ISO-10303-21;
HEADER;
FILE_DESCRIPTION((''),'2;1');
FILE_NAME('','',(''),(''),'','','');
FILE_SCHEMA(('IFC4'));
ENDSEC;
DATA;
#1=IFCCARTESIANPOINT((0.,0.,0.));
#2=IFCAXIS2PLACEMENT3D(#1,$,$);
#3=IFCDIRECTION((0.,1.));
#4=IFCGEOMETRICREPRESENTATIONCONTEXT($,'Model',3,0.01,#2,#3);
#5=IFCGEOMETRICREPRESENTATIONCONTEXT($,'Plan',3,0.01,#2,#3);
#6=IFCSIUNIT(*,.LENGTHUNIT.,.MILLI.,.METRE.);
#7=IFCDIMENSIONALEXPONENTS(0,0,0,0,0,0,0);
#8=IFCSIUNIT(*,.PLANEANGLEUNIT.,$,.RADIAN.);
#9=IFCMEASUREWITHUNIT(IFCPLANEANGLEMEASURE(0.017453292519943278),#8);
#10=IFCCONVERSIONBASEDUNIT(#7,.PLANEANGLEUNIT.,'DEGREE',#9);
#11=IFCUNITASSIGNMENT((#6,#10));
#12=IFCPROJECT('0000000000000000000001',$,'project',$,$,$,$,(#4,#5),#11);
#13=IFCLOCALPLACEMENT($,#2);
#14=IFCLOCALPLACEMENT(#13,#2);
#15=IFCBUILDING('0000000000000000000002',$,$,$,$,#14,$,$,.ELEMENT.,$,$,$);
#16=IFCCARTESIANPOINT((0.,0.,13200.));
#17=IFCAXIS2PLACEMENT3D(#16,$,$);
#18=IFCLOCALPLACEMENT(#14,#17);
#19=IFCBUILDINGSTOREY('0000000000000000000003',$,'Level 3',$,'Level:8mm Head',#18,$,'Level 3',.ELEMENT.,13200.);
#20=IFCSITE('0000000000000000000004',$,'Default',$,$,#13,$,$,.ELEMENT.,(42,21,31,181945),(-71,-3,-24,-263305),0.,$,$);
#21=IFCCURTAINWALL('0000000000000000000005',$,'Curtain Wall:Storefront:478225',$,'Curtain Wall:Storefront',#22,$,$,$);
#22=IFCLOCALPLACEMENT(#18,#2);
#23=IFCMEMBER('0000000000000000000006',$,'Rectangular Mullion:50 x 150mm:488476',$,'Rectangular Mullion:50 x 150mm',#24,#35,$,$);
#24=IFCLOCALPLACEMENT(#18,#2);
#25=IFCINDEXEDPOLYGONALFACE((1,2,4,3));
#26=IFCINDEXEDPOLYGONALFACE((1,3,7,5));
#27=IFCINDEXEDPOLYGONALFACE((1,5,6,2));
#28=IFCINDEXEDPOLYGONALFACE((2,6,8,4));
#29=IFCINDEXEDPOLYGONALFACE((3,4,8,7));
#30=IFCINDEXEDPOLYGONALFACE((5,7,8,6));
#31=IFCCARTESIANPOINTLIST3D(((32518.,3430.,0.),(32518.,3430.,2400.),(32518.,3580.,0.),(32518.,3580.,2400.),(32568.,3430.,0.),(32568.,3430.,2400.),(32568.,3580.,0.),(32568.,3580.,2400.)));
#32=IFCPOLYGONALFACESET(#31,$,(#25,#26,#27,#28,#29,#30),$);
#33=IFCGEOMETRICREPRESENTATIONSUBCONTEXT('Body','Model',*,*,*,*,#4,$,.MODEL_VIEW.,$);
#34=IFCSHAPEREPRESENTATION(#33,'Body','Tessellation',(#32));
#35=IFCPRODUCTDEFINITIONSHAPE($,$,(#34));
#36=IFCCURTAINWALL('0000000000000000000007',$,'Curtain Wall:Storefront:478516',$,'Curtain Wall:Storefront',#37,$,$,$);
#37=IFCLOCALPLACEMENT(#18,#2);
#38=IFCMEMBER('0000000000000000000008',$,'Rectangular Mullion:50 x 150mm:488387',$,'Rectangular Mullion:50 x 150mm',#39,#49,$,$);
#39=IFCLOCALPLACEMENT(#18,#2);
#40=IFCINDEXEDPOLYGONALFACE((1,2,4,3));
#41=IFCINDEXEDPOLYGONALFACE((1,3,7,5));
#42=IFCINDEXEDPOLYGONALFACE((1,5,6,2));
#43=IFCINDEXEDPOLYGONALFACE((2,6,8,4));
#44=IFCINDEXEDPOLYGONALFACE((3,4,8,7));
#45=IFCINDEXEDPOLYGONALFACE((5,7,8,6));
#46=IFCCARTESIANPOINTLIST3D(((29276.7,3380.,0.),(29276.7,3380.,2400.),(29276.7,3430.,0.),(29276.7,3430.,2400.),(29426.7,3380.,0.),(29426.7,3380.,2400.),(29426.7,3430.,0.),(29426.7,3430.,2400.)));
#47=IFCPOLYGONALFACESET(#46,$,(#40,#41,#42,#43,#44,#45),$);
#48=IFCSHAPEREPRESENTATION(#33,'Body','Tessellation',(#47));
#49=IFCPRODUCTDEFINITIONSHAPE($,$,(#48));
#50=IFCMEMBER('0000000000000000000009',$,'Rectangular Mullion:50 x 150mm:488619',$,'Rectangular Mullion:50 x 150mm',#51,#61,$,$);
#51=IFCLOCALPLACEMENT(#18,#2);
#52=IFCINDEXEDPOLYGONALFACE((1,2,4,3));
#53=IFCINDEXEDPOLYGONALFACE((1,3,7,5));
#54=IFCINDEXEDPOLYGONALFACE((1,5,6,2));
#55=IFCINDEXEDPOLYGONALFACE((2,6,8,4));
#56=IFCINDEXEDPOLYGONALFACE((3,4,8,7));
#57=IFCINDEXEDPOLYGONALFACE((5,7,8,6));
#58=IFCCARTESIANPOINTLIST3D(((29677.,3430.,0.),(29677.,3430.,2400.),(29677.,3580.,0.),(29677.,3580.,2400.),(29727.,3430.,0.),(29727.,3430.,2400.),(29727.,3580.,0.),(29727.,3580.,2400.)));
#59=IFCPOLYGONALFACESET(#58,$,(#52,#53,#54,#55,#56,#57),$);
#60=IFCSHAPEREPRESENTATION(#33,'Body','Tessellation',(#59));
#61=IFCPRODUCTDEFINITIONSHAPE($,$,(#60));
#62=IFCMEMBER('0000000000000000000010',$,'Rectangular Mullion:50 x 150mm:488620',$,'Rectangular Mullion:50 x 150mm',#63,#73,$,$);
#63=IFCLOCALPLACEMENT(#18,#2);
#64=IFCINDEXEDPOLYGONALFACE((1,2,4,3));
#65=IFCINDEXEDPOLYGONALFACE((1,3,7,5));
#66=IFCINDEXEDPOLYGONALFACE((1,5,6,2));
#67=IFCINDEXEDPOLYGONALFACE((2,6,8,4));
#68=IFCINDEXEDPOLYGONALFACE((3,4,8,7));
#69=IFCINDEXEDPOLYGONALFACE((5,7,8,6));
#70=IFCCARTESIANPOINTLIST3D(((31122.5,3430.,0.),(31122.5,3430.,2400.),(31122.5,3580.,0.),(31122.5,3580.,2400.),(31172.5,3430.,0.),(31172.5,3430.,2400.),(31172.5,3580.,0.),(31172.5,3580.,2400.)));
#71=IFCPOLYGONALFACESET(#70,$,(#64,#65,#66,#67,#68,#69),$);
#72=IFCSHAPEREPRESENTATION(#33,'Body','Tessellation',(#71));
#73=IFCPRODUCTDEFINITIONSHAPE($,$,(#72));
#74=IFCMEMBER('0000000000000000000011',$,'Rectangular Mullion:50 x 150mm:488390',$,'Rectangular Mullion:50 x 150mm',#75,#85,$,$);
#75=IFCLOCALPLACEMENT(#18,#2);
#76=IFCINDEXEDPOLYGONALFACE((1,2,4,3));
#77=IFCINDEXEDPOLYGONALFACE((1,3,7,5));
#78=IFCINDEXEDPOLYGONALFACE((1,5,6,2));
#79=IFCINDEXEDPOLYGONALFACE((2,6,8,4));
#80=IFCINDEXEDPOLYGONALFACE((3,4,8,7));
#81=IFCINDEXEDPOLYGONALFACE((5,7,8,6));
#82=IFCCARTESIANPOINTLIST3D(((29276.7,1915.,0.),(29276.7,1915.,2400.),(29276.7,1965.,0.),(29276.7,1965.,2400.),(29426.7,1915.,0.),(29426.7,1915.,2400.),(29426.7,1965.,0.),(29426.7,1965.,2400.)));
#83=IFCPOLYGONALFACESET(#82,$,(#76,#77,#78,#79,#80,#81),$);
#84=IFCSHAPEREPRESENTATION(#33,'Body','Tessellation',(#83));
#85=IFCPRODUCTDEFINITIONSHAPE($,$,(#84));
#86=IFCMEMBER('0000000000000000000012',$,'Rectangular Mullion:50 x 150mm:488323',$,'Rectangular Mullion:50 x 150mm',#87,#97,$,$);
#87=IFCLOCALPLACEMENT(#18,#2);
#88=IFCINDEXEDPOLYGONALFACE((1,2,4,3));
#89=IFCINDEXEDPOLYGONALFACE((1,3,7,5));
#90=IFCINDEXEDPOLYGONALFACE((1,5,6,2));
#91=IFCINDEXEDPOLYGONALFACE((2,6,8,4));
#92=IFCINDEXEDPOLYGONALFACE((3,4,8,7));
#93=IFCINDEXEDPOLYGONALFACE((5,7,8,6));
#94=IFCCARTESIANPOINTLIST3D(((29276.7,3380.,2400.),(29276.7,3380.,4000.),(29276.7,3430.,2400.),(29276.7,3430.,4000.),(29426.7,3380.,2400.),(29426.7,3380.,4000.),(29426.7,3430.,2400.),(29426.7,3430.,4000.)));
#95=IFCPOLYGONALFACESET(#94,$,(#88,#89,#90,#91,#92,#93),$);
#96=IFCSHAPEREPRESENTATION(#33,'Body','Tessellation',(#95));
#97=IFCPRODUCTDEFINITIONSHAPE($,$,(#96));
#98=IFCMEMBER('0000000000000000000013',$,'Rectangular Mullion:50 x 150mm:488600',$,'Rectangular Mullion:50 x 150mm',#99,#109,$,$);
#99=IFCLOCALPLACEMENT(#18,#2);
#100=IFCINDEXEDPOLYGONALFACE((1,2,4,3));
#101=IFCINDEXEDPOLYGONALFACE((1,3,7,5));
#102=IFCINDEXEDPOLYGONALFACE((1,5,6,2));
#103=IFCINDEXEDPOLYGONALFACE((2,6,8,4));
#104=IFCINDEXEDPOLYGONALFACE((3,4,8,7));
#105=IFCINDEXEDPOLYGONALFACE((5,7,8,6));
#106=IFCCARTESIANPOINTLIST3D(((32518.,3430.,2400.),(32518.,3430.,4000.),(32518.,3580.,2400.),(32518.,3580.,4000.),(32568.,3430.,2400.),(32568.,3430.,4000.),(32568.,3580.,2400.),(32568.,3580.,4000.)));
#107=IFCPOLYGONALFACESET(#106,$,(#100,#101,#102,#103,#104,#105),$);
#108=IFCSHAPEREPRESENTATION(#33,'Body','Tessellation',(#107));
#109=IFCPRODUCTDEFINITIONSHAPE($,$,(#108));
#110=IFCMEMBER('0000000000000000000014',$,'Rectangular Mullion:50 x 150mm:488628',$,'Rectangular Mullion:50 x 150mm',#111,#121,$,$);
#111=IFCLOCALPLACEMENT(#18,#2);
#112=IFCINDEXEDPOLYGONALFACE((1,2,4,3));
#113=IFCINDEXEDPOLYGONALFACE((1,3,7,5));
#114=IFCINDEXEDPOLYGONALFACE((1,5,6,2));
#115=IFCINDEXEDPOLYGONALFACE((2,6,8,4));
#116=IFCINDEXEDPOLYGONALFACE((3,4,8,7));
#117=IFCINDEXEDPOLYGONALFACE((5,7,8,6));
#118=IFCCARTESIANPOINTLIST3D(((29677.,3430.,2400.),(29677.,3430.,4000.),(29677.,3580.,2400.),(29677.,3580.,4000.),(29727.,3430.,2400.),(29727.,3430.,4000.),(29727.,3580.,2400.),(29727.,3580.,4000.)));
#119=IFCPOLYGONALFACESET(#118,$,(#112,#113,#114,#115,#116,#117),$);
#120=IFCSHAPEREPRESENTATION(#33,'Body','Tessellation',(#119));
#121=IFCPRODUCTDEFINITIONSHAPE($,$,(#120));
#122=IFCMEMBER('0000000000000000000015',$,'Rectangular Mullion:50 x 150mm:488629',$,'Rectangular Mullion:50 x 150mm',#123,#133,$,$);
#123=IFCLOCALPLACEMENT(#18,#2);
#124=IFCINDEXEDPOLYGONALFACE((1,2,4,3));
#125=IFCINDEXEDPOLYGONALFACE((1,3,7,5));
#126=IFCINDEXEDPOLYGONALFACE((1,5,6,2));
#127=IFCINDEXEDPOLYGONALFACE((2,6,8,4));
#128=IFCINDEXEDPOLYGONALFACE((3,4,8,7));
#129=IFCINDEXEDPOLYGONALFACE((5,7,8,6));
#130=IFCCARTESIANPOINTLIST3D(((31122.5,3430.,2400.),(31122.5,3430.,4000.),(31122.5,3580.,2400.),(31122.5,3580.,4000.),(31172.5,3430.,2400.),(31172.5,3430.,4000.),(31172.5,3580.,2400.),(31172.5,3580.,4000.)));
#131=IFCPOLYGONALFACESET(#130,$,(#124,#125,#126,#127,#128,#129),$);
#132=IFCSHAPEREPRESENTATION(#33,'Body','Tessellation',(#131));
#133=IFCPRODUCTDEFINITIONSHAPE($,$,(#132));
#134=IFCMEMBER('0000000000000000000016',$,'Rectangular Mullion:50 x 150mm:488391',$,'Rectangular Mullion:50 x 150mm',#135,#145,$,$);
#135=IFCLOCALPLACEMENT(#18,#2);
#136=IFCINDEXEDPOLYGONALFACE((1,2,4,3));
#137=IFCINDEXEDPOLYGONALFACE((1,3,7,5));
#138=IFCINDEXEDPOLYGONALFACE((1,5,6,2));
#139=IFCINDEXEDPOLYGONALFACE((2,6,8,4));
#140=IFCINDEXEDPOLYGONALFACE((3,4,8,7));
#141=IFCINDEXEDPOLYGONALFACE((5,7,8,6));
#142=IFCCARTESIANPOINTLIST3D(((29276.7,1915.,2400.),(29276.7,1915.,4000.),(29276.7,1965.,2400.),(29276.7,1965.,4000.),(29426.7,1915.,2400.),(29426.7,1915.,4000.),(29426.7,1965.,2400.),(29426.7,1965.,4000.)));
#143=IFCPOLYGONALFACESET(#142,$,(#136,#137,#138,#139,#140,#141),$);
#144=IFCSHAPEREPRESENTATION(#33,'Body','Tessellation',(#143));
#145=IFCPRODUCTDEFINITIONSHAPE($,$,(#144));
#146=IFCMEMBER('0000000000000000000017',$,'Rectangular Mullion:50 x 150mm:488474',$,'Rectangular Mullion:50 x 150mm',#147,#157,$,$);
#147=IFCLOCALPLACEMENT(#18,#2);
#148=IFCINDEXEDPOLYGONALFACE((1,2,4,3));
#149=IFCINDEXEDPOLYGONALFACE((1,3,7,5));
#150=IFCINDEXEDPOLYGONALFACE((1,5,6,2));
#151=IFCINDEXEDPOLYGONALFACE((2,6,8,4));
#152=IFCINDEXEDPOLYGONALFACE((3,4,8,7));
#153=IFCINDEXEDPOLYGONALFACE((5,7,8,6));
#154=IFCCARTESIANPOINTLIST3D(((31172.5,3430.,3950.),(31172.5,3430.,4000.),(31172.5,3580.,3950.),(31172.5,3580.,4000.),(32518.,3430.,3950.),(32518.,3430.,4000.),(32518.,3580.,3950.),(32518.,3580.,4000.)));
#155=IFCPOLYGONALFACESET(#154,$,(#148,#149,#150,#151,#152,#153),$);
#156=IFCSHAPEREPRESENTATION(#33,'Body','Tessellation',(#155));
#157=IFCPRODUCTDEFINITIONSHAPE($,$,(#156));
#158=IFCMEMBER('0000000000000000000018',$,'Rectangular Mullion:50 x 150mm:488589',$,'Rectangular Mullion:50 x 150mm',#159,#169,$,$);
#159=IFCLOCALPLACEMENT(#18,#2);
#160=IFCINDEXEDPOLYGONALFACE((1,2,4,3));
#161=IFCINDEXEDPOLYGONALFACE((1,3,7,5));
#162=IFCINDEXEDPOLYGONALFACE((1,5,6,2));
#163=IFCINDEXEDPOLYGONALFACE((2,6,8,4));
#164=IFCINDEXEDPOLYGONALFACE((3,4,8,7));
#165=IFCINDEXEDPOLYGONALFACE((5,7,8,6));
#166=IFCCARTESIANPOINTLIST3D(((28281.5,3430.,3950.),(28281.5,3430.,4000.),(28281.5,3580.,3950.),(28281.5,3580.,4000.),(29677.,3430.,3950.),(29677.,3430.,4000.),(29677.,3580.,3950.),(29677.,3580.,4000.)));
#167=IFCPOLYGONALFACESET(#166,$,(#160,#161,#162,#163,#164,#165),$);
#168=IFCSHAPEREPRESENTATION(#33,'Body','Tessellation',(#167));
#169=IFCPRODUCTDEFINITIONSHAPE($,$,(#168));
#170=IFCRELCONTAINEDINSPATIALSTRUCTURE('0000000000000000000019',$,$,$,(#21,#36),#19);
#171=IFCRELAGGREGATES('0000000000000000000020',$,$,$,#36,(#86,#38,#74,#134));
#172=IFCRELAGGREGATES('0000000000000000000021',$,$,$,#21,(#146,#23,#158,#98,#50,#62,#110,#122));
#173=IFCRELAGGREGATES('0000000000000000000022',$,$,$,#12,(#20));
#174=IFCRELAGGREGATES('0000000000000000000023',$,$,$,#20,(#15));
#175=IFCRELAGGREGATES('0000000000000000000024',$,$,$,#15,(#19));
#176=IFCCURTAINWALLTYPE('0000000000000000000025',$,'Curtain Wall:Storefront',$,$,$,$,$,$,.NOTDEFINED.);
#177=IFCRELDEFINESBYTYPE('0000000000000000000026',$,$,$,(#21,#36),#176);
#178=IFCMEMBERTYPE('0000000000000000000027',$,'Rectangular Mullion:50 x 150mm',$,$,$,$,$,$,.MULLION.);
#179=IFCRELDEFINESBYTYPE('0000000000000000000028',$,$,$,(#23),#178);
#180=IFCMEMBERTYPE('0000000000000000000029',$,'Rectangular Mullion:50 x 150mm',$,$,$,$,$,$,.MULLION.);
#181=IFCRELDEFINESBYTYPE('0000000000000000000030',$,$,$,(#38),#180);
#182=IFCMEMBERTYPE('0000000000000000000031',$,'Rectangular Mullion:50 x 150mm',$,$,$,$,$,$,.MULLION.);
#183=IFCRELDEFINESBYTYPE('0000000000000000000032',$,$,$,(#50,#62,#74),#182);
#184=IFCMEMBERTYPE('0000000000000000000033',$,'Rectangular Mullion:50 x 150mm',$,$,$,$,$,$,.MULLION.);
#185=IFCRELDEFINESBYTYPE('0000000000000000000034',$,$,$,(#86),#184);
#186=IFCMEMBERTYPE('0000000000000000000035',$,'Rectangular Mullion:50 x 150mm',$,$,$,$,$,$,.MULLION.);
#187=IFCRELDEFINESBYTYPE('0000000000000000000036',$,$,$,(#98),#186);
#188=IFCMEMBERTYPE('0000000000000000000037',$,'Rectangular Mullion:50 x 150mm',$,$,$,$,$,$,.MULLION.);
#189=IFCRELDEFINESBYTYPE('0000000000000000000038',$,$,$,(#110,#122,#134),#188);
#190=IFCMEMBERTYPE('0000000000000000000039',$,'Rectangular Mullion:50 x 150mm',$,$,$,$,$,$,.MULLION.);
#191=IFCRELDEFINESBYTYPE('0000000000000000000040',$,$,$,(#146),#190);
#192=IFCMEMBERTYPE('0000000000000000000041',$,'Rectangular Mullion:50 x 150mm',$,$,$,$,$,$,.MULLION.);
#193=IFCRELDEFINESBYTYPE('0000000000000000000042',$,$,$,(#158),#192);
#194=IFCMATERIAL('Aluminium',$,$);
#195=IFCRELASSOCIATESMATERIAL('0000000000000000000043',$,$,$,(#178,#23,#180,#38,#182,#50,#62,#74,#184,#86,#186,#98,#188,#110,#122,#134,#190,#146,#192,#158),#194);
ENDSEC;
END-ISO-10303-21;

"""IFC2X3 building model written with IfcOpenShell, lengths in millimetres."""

from ifc_helpers import new_model, entity, si_unit, converted_unit, direction, frame, origin, origin_2d_with_axis, place, context, subcontext, project, spatial, rectangle, extrude, source, transform, mapped, material, type_object, type_shapes, element, aggregate, save


model = new_model("IFC2X3")

# Units and contexts
model_context = context("Model", 3, precision=0.01, world=origin(), true_north=direction((0.0, 1.0)))
plan_context = context("Plan", 3, precision=0.01, world=origin(), true_north=direction((0.0, 1.0)))
body_context = subcontext(model_context, "Body", "Model", "MODEL_VIEW")
ifc_project = project(units=[si_unit("LENGTHUNIT", "METRE", prefix="MILLI"), converted_unit("PLANEANGLEUNIT", "DEGREE", entity("IfcPlaneAngleMeasure", 0.017453292519943278), si_unit("PLANEANGLEUNIT", "RADIAN"), dimensions=[0, 0, 0, 0, 0, 0, 0])], contexts=[model_context, plan_context])

# Site, building, storey
site_placement = place(None, origin())
site = spatial("IfcSite", under=ifc_project, at=site_placement, Name="Default", CompositionType="ELEMENT", RefLatitude=(42, 21, 31, 181945), RefLongitude=(-71, -3, -24, -263305), RefElevation=0.0)
building_placement = place(site_placement, origin())
building = spatial("IfcBuilding", under=site, at=building_placement, CompositionType="ELEMENT")
storey_placement = place(building_placement, frame((0.0, 0.0, 13200.0)))
storey = spatial("IfcBuildingStorey", under=building, at=storey_placement, Name="Level 3", ObjectType="Level:8mm Head", LongName="Level 3", CompositionType="ELEMENT", Elevation=13200.0)

# Curtain walls, members
curtain_wall_type = type_object("IfcCurtainWallType", Name="Curtain Wall:Storefront", PredefinedType="NOTDEFINED")
curtain_wall_1_placement = place(storey_placement, frame((0.0, 0.0, -13200.0)))
curtain_wall_1 = element("IfcCurtainWall", 1, at=curtain_wall_1_placement, inside=storey, type_object=curtain_wall_type, Name="Curtain Wall:Storefront:478225", ObjectType="Curtain Wall:Storefront")
ifc_material_1 = material(Name="Aluminium")
member_type_1 = type_object("IfcMemberType", Name="Rectangular Mullion:50 x 150mm", PredefinedType="MULLION", material=ifc_material_1)
shared_shape_1 = source(origin(), body_context, "Body", "SweptSolid", [
    extrude(rectangle(XDim=50.0, YDim=150.0, at=origin_2d_with_axis()), frame((-25.0, 0.0, -2400.0), z_axis=(0.0, 0.0, 1.0), x_axis=(-1.0, 0.0, 0.0)), (0.0, 0.0, 1.0), 2400.0),
])
type_shapes(member_type_1, [shared_shape_1])
member_1_placement = place(curtain_wall_1_placement, frame((32568.0, 3505.0, 13200.0), z_axis=(0.0, 0.0, -1.0), x_axis=(1.0, 0.0, 0.0)))
member_1 = element("IfcMember", 2, at=member_1_placement, type_object=member_type_1, material=ifc_material_1, Name="Rectangular Mullion:50 x 150mm:488476", ObjectType="Rectangular Mullion:50 x 150mm", context=body_context, shape_type="MappedRepresentation", body=[
    mapped(shared_shape_1, transform((0.0, 0.0, 0.0), scale=1.0)),
])
curtain_wall_2_placement = place(storey_placement, frame((0.0, 0.0, -13200.0)))
curtain_wall_2 = element("IfcCurtainWall", 3, at=curtain_wall_2_placement, inside=storey, type_object=curtain_wall_type, Name="Curtain Wall:Storefront:478516", ObjectType="Curtain Wall:Storefront")
member_type_2 = type_object("IfcMemberType", Name="Rectangular Mullion:50 x 150mm", PredefinedType="MULLION", material=ifc_material_1)
shared_shape_2 = source(origin(), body_context, "Body", "SweptSolid", [
    extrude(rectangle(XDim=50.0, YDim=150.0, at=origin_2d_with_axis()), frame((-25.0, 0.0, -2400.0), z_axis=(0.0, 0.0, 1.0), x_axis=(-1.0, 0.0, 0.0)), (0.0, 0.0, 1.0), 2400.0),
])
type_shapes(member_type_2, [shared_shape_2])
member_2_placement = place(curtain_wall_2_placement, frame((29351.7, 3430.0, 15600.0), z_axis=(0.0, 0.0, 1.0), x_axis=(0.0, 1.0, 0.0)))
member_2 = element("IfcMember", 4, at=member_2_placement, type_object=member_type_2, material=ifc_material_1, Name="Rectangular Mullion:50 x 150mm:488387", ObjectType="Rectangular Mullion:50 x 150mm", context=body_context, shape_type="MappedRepresentation", body=[
    mapped(shared_shape_2, transform((0.0, 0.0, 0.0), scale=1.0)),
])

# Members
member_type_3 = type_object("IfcMemberType", Name="Rectangular Mullion:50 x 150mm", PredefinedType="MULLION", material=ifc_material_1)
shared_shape_3 = source(origin(), body_context, "Body", "SweptSolid", [
    extrude(rectangle(XDim=50.0, YDim=150.0, at=origin_2d_with_axis()), frame((0.0, 0.0, -2400.0), z_axis=(0.0, 0.0, 1.0), x_axis=(-1.0, 0.0, 0.0)), (0.0, 0.0, 1.0), 2400.0),
])
type_shapes(member_type_3, [shared_shape_3])
member_3_placement = place(curtain_wall_1_placement, frame((29702.0, 3505.0, 13200.0), z_axis=(0.0, 0.0, -1.0), x_axis=(1.0, 0.0, 0.0)))
member_3 = element("IfcMember", 5, at=member_3_placement, type_object=member_type_3, material=ifc_material_1, Name="Rectangular Mullion:50 x 150mm:488619", ObjectType="Rectangular Mullion:50 x 150mm", context=body_context, shape_type="MappedRepresentation", body=[
    mapped(shared_shape_3, transform((0.0, 0.0, 0.0), scale=1.0)),
])
member_4_placement = place(curtain_wall_1_placement, frame((31147.5, 3505.0, 13200.0), z_axis=(0.0, 0.0, -1.0), x_axis=(1.0, 0.0, 0.0)))
member_4 = element("IfcMember", 6, at=member_4_placement, type_object=member_type_3, material=ifc_material_1, Name="Rectangular Mullion:50 x 150mm:488620", ObjectType="Rectangular Mullion:50 x 150mm", context=body_context, shape_type="MappedRepresentation", body=[
    mapped(shared_shape_3, transform((0.0, 0.0, 0.0), scale=1.0)),
])
member_5_placement = place(curtain_wall_2_placement, frame((29351.7, 1940.0, 13200.0), z_axis=(0.0, 0.0, -1.0), x_axis=(0.0, -1.0, 0.0)))
member_5 = element("IfcMember", 7, at=member_5_placement, type_object=member_type_3, material=ifc_material_1, Name="Rectangular Mullion:50 x 150mm:488390", ObjectType="Rectangular Mullion:50 x 150mm", context=body_context, shape_type="MappedRepresentation", body=[
    mapped(shared_shape_3, transform((0.0, 0.0, 0.0), scale=1.0)),
])
member_type_4 = type_object("IfcMemberType", Name="Rectangular Mullion:50 x 150mm", PredefinedType="MULLION", material=ifc_material_1)
shared_shape_4 = source(origin(), body_context, "Body", "SweptSolid", [
    extrude(rectangle(XDim=50.0, YDim=150.0, at=origin_2d_with_axis()), frame((-25.0, 0.0, -1600.0), z_axis=(0.0, 0.0, 1.0), x_axis=(-1.0, 0.0, 0.0)), (0.0, 0.0, 1.0), 1600.0),
])
type_shapes(member_type_4, [shared_shape_4])
member_6_placement = place(curtain_wall_2_placement, frame((29351.7, 3430.0, 17200.0), z_axis=(0.0, 0.0, 1.0), x_axis=(0.0, 1.0, 0.0)))
member_6 = element("IfcMember", 8, at=member_6_placement, type_object=member_type_4, material=ifc_material_1, Name="Rectangular Mullion:50 x 150mm:488323", ObjectType="Rectangular Mullion:50 x 150mm", context=body_context, shape_type="MappedRepresentation", body=[
    mapped(shared_shape_4, transform((0.0, 0.0, 0.0), scale=1.0)),
])
member_type_5 = type_object("IfcMemberType", Name="Rectangular Mullion:50 x 150mm", PredefinedType="MULLION", material=ifc_material_1)
shared_shape_5 = source(origin(), body_context, "Body", "SweptSolid", [
    extrude(rectangle(XDim=50.0, YDim=150.0, at=origin_2d_with_axis()), frame((-25.0, 0.0, -1600.0), z_axis=(0.0, 0.0, 1.0), x_axis=(-1.0, 0.0, 0.0)), (0.0, 0.0, 1.0), 1600.0),
])
type_shapes(member_type_5, [shared_shape_5])
member_7_placement = place(curtain_wall_1_placement, frame((32568.0, 3505.0, 15600.0), z_axis=(0.0, 0.0, -1.0), x_axis=(1.0, 0.0, 0.0)))
member_7 = element("IfcMember", 9, at=member_7_placement, type_object=member_type_5, material=ifc_material_1, Name="Rectangular Mullion:50 x 150mm:488600", ObjectType="Rectangular Mullion:50 x 150mm", context=body_context, shape_type="MappedRepresentation", body=[
    mapped(shared_shape_5, transform((0.0, 0.0, 0.0), scale=1.0)),
])
member_type_6 = type_object("IfcMemberType", Name="Rectangular Mullion:50 x 150mm", PredefinedType="MULLION", material=ifc_material_1)
shared_shape_6 = source(origin(), body_context, "Body", "SweptSolid", [
    extrude(rectangle(XDim=50.0, YDim=150.0, at=origin_2d_with_axis()), frame((0.0, 0.0, -1600.0), z_axis=(0.0, 0.0, 1.0), x_axis=(-1.0, 0.0, 0.0)), (0.0, 0.0, 1.0), 1600.0),
])
type_shapes(member_type_6, [shared_shape_6])
member_8_placement = place(curtain_wall_1_placement, frame((29702.0, 3505.0, 15600.0), z_axis=(0.0, 0.0, -1.0), x_axis=(1.0, 0.0, 0.0)))
member_8 = element("IfcMember", 10, at=member_8_placement, type_object=member_type_6, material=ifc_material_1, Name="Rectangular Mullion:50 x 150mm:488628", ObjectType="Rectangular Mullion:50 x 150mm", context=body_context, shape_type="MappedRepresentation", body=[
    mapped(shared_shape_6, transform((0.0, 0.0, 0.0), scale=1.0)),
])
member_9_placement = place(curtain_wall_1_placement, frame((31147.5, 3505.0, 15600.0), z_axis=(0.0, 0.0, -1.0), x_axis=(1.0, 0.0, 0.0)))
member_9 = element("IfcMember", 11, at=member_9_placement, type_object=member_type_6, material=ifc_material_1, Name="Rectangular Mullion:50 x 150mm:488629", ObjectType="Rectangular Mullion:50 x 150mm", context=body_context, shape_type="MappedRepresentation", body=[
    mapped(shared_shape_6, transform((0.0, 0.0, 0.0), scale=1.0)),
])
member_10_placement = place(curtain_wall_2_placement, frame((29351.7, 1940.0, 15600.0), z_axis=(0.0, 0.0, -1.0), x_axis=(0.0, -1.0, 0.0)))
member_10 = element("IfcMember", 12, at=member_10_placement, type_object=member_type_6, material=ifc_material_1, Name="Rectangular Mullion:50 x 150mm:488391", ObjectType="Rectangular Mullion:50 x 150mm", context=body_context, shape_type="MappedRepresentation", body=[
    mapped(shared_shape_6, transform((0.0, 0.0, 0.0), scale=1.0)),
])
member_type_7 = type_object("IfcMemberType", Name="Rectangular Mullion:50 x 150mm", PredefinedType="MULLION", material=ifc_material_1)
shared_shape_7 = source(origin(), body_context, "Body", "SweptSolid", [
    extrude(rectangle(XDim=50.0, YDim=150.0, at=origin_2d_with_axis()), frame((-25.0, 0.0, -1345.5), z_axis=(0.0, 0.0, 1.0), x_axis=(-1.0, 0.0, 0.0)), (0.0, 0.0, 1.0), 1345.5),
])
type_shapes(member_type_7, [shared_shape_7])
member_11_placement = place(curtain_wall_1_placement, frame((32518.0, 3505.0, 17200.0), z_axis=(1.0, 0.0, 0.0), x_axis=(0.0, 0.0, 1.0)))
member_11 = element("IfcMember", 13, at=member_11_placement, type_object=member_type_7, material=ifc_material_1, Name="Rectangular Mullion:50 x 150mm:488474", ObjectType="Rectangular Mullion:50 x 150mm", context=body_context, shape_type="MappedRepresentation", body=[
    mapped(shared_shape_7, transform((0.0, 0.0, 0.0), scale=1.0)),
])
member_type_8 = type_object("IfcMemberType", Name="Rectangular Mullion:50 x 150mm", PredefinedType="MULLION", material=ifc_material_1)
shared_shape_8 = source(origin(), body_context, "Body", "SweptSolid", [
    extrude(rectangle(XDim=50.0, YDim=150.0, at=origin_2d_with_axis()), frame((-25.0, 0.0, -1395.5), z_axis=(0.0, 0.0, 1.0), x_axis=(-1.0, 0.0, 0.0)), (0.0, 0.0, 1.0), 1395.5),
])
type_shapes(member_type_8, [shared_shape_8])
member_12_placement = place(curtain_wall_1_placement, frame((29677.0, 3505.0, 17200.0), z_axis=(1.0, 0.0, 0.0), x_axis=(0.0, 0.0, 1.0)))
member_12 = element("IfcMember", 14, at=member_12_placement, type_object=member_type_8, material=ifc_material_1, Name="Rectangular Mullion:50 x 150mm:488589", ObjectType="Rectangular Mullion:50 x 150mm", context=body_context, shape_type="MappedRepresentation", body=[
    mapped(shared_shape_8, transform((0.0, 0.0, 0.0), scale=1.0)),
])

aggregate(curtain_wall_2, [member_6, member_2, member_5, member_10])

aggregate(curtain_wall_1, [member_11, member_1, member_12, member_7, member_3, member_4, member_8, member_9])

save(model, "model.ifc")
